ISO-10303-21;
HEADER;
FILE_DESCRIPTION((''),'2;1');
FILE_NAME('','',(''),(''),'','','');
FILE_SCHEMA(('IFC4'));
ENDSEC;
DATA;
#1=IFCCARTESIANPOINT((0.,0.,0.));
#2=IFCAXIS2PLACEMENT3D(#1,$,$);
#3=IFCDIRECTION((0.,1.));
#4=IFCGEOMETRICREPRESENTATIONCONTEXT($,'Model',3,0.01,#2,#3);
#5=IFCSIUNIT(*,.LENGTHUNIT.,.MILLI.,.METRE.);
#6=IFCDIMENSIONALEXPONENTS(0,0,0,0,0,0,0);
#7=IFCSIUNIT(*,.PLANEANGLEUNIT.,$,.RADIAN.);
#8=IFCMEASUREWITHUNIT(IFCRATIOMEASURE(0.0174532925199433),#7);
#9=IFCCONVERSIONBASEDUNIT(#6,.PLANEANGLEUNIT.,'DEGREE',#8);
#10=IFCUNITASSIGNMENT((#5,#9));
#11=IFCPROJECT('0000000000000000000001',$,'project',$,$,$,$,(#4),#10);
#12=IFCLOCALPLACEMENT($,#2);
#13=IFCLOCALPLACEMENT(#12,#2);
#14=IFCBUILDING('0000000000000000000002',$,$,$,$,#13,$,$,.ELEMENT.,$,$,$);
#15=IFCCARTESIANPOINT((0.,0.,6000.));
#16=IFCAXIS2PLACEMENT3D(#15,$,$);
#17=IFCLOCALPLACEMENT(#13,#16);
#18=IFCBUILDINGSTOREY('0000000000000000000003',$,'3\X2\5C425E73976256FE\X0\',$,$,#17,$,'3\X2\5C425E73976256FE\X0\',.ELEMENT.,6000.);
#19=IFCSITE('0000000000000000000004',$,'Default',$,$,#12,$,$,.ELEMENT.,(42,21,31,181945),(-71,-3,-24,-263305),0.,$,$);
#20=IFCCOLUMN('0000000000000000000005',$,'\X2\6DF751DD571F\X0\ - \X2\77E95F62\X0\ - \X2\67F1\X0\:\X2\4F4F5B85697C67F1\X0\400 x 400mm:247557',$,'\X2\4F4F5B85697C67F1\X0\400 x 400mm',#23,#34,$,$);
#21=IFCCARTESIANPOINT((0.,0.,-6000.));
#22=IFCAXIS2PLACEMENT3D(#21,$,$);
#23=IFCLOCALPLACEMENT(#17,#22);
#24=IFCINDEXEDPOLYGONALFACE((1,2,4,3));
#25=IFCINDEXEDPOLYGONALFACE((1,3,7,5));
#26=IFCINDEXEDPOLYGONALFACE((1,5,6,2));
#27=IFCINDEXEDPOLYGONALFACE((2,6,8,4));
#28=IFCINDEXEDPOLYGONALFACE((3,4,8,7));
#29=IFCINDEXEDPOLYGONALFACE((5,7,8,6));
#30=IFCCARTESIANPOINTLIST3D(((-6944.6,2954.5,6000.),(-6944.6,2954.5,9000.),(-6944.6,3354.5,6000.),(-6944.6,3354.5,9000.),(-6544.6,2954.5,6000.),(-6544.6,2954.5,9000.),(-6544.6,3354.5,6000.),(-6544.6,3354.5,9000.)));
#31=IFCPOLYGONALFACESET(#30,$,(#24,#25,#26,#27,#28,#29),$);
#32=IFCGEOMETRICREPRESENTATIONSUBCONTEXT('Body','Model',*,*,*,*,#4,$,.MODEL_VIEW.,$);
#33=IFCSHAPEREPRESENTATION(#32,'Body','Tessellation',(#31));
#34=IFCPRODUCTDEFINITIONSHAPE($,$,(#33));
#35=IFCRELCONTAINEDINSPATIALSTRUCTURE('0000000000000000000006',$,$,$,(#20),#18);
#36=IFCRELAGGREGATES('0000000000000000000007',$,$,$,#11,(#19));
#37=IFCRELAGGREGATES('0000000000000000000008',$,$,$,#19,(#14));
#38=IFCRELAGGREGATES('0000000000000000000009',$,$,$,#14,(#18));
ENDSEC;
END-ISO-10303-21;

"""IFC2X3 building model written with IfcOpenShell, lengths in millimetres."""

from ifc_helpers import new_model, entity, si_unit, converted_unit, direction, frame, origin, origin_2d_with_axis, place, context, subcontext, project, spatial, rectangle, extrude, source, transform, mapped, element, save


model = new_model("IFC2X3")

# Units and contexts
model_context = context("Model", 3, precision=0.01, world=origin(), true_north=direction((0.0, 1.0)))
body_context = subcontext(model_context, "Body", "Model", "MODEL_VIEW")
ifc_project = project(units=[si_unit("LENGTHUNIT", "METRE", prefix="MILLI"), converted_unit("PLANEANGLEUNIT", "DEGREE", entity("IfcRatioMeasure", 0.0174532925199433), si_unit("PLANEANGLEUNIT", "RADIAN"), dimensions=[0, 0, 0, 0, 0, 0, 0])], contexts=[model_context])

# Site, building, storey
site_placement = place(None, origin())
site = spatial("IfcSite", under=ifc_project, at=site_placement, Name="Default", CompositionType="ELEMENT", RefLatitude=(42, 21, 31, 181945), RefLongitude=(-71, -3, -24, -263305), RefElevation=0.0)
building_placement = place(site_placement, origin())
building = spatial("IfcBuilding", under=site, at=building_placement, CompositionType="ELEMENT")
storey_placement = place(building_placement, frame((0.0, 0.0, 6000.0)))
storey = spatial("IfcBuildingStorey", under=building, at=storey_placement, Name="3层平面图", LongName="3层平面图", CompositionType="ELEMENT", Elevation=6000.0)

# Column
shared_shape = source(origin(), body_context, "Body", "SweptSolid", [
    extrude(rectangle(XDim=400.0, YDim=400.0, at=origin_2d_with_axis()), frame((-6744.6, 3154.5, 6000.0), z_axis=(0.0, 0.0, 1.0), x_axis=(0.0, -1.0, 0.0)), (0.0, 0.0, 1.0), 3000.0),
])
column_placement = place(storey_placement, frame((0.0, 0.0, -6000.0)))
element("IfcColumn", 1, at=column_placement, inside=storey, Name="混凝土 - 矩形 - 柱:住宅楼柱400 x 400mm:247557", ObjectType="住宅楼柱400 x 400mm", context=body_context, shape_type="MappedRepresentation", body=[
    mapped(shared_shape, transform((0.0, 0.0, 0.0), scale=1.0)),
])

save(model, "model.ifc")
